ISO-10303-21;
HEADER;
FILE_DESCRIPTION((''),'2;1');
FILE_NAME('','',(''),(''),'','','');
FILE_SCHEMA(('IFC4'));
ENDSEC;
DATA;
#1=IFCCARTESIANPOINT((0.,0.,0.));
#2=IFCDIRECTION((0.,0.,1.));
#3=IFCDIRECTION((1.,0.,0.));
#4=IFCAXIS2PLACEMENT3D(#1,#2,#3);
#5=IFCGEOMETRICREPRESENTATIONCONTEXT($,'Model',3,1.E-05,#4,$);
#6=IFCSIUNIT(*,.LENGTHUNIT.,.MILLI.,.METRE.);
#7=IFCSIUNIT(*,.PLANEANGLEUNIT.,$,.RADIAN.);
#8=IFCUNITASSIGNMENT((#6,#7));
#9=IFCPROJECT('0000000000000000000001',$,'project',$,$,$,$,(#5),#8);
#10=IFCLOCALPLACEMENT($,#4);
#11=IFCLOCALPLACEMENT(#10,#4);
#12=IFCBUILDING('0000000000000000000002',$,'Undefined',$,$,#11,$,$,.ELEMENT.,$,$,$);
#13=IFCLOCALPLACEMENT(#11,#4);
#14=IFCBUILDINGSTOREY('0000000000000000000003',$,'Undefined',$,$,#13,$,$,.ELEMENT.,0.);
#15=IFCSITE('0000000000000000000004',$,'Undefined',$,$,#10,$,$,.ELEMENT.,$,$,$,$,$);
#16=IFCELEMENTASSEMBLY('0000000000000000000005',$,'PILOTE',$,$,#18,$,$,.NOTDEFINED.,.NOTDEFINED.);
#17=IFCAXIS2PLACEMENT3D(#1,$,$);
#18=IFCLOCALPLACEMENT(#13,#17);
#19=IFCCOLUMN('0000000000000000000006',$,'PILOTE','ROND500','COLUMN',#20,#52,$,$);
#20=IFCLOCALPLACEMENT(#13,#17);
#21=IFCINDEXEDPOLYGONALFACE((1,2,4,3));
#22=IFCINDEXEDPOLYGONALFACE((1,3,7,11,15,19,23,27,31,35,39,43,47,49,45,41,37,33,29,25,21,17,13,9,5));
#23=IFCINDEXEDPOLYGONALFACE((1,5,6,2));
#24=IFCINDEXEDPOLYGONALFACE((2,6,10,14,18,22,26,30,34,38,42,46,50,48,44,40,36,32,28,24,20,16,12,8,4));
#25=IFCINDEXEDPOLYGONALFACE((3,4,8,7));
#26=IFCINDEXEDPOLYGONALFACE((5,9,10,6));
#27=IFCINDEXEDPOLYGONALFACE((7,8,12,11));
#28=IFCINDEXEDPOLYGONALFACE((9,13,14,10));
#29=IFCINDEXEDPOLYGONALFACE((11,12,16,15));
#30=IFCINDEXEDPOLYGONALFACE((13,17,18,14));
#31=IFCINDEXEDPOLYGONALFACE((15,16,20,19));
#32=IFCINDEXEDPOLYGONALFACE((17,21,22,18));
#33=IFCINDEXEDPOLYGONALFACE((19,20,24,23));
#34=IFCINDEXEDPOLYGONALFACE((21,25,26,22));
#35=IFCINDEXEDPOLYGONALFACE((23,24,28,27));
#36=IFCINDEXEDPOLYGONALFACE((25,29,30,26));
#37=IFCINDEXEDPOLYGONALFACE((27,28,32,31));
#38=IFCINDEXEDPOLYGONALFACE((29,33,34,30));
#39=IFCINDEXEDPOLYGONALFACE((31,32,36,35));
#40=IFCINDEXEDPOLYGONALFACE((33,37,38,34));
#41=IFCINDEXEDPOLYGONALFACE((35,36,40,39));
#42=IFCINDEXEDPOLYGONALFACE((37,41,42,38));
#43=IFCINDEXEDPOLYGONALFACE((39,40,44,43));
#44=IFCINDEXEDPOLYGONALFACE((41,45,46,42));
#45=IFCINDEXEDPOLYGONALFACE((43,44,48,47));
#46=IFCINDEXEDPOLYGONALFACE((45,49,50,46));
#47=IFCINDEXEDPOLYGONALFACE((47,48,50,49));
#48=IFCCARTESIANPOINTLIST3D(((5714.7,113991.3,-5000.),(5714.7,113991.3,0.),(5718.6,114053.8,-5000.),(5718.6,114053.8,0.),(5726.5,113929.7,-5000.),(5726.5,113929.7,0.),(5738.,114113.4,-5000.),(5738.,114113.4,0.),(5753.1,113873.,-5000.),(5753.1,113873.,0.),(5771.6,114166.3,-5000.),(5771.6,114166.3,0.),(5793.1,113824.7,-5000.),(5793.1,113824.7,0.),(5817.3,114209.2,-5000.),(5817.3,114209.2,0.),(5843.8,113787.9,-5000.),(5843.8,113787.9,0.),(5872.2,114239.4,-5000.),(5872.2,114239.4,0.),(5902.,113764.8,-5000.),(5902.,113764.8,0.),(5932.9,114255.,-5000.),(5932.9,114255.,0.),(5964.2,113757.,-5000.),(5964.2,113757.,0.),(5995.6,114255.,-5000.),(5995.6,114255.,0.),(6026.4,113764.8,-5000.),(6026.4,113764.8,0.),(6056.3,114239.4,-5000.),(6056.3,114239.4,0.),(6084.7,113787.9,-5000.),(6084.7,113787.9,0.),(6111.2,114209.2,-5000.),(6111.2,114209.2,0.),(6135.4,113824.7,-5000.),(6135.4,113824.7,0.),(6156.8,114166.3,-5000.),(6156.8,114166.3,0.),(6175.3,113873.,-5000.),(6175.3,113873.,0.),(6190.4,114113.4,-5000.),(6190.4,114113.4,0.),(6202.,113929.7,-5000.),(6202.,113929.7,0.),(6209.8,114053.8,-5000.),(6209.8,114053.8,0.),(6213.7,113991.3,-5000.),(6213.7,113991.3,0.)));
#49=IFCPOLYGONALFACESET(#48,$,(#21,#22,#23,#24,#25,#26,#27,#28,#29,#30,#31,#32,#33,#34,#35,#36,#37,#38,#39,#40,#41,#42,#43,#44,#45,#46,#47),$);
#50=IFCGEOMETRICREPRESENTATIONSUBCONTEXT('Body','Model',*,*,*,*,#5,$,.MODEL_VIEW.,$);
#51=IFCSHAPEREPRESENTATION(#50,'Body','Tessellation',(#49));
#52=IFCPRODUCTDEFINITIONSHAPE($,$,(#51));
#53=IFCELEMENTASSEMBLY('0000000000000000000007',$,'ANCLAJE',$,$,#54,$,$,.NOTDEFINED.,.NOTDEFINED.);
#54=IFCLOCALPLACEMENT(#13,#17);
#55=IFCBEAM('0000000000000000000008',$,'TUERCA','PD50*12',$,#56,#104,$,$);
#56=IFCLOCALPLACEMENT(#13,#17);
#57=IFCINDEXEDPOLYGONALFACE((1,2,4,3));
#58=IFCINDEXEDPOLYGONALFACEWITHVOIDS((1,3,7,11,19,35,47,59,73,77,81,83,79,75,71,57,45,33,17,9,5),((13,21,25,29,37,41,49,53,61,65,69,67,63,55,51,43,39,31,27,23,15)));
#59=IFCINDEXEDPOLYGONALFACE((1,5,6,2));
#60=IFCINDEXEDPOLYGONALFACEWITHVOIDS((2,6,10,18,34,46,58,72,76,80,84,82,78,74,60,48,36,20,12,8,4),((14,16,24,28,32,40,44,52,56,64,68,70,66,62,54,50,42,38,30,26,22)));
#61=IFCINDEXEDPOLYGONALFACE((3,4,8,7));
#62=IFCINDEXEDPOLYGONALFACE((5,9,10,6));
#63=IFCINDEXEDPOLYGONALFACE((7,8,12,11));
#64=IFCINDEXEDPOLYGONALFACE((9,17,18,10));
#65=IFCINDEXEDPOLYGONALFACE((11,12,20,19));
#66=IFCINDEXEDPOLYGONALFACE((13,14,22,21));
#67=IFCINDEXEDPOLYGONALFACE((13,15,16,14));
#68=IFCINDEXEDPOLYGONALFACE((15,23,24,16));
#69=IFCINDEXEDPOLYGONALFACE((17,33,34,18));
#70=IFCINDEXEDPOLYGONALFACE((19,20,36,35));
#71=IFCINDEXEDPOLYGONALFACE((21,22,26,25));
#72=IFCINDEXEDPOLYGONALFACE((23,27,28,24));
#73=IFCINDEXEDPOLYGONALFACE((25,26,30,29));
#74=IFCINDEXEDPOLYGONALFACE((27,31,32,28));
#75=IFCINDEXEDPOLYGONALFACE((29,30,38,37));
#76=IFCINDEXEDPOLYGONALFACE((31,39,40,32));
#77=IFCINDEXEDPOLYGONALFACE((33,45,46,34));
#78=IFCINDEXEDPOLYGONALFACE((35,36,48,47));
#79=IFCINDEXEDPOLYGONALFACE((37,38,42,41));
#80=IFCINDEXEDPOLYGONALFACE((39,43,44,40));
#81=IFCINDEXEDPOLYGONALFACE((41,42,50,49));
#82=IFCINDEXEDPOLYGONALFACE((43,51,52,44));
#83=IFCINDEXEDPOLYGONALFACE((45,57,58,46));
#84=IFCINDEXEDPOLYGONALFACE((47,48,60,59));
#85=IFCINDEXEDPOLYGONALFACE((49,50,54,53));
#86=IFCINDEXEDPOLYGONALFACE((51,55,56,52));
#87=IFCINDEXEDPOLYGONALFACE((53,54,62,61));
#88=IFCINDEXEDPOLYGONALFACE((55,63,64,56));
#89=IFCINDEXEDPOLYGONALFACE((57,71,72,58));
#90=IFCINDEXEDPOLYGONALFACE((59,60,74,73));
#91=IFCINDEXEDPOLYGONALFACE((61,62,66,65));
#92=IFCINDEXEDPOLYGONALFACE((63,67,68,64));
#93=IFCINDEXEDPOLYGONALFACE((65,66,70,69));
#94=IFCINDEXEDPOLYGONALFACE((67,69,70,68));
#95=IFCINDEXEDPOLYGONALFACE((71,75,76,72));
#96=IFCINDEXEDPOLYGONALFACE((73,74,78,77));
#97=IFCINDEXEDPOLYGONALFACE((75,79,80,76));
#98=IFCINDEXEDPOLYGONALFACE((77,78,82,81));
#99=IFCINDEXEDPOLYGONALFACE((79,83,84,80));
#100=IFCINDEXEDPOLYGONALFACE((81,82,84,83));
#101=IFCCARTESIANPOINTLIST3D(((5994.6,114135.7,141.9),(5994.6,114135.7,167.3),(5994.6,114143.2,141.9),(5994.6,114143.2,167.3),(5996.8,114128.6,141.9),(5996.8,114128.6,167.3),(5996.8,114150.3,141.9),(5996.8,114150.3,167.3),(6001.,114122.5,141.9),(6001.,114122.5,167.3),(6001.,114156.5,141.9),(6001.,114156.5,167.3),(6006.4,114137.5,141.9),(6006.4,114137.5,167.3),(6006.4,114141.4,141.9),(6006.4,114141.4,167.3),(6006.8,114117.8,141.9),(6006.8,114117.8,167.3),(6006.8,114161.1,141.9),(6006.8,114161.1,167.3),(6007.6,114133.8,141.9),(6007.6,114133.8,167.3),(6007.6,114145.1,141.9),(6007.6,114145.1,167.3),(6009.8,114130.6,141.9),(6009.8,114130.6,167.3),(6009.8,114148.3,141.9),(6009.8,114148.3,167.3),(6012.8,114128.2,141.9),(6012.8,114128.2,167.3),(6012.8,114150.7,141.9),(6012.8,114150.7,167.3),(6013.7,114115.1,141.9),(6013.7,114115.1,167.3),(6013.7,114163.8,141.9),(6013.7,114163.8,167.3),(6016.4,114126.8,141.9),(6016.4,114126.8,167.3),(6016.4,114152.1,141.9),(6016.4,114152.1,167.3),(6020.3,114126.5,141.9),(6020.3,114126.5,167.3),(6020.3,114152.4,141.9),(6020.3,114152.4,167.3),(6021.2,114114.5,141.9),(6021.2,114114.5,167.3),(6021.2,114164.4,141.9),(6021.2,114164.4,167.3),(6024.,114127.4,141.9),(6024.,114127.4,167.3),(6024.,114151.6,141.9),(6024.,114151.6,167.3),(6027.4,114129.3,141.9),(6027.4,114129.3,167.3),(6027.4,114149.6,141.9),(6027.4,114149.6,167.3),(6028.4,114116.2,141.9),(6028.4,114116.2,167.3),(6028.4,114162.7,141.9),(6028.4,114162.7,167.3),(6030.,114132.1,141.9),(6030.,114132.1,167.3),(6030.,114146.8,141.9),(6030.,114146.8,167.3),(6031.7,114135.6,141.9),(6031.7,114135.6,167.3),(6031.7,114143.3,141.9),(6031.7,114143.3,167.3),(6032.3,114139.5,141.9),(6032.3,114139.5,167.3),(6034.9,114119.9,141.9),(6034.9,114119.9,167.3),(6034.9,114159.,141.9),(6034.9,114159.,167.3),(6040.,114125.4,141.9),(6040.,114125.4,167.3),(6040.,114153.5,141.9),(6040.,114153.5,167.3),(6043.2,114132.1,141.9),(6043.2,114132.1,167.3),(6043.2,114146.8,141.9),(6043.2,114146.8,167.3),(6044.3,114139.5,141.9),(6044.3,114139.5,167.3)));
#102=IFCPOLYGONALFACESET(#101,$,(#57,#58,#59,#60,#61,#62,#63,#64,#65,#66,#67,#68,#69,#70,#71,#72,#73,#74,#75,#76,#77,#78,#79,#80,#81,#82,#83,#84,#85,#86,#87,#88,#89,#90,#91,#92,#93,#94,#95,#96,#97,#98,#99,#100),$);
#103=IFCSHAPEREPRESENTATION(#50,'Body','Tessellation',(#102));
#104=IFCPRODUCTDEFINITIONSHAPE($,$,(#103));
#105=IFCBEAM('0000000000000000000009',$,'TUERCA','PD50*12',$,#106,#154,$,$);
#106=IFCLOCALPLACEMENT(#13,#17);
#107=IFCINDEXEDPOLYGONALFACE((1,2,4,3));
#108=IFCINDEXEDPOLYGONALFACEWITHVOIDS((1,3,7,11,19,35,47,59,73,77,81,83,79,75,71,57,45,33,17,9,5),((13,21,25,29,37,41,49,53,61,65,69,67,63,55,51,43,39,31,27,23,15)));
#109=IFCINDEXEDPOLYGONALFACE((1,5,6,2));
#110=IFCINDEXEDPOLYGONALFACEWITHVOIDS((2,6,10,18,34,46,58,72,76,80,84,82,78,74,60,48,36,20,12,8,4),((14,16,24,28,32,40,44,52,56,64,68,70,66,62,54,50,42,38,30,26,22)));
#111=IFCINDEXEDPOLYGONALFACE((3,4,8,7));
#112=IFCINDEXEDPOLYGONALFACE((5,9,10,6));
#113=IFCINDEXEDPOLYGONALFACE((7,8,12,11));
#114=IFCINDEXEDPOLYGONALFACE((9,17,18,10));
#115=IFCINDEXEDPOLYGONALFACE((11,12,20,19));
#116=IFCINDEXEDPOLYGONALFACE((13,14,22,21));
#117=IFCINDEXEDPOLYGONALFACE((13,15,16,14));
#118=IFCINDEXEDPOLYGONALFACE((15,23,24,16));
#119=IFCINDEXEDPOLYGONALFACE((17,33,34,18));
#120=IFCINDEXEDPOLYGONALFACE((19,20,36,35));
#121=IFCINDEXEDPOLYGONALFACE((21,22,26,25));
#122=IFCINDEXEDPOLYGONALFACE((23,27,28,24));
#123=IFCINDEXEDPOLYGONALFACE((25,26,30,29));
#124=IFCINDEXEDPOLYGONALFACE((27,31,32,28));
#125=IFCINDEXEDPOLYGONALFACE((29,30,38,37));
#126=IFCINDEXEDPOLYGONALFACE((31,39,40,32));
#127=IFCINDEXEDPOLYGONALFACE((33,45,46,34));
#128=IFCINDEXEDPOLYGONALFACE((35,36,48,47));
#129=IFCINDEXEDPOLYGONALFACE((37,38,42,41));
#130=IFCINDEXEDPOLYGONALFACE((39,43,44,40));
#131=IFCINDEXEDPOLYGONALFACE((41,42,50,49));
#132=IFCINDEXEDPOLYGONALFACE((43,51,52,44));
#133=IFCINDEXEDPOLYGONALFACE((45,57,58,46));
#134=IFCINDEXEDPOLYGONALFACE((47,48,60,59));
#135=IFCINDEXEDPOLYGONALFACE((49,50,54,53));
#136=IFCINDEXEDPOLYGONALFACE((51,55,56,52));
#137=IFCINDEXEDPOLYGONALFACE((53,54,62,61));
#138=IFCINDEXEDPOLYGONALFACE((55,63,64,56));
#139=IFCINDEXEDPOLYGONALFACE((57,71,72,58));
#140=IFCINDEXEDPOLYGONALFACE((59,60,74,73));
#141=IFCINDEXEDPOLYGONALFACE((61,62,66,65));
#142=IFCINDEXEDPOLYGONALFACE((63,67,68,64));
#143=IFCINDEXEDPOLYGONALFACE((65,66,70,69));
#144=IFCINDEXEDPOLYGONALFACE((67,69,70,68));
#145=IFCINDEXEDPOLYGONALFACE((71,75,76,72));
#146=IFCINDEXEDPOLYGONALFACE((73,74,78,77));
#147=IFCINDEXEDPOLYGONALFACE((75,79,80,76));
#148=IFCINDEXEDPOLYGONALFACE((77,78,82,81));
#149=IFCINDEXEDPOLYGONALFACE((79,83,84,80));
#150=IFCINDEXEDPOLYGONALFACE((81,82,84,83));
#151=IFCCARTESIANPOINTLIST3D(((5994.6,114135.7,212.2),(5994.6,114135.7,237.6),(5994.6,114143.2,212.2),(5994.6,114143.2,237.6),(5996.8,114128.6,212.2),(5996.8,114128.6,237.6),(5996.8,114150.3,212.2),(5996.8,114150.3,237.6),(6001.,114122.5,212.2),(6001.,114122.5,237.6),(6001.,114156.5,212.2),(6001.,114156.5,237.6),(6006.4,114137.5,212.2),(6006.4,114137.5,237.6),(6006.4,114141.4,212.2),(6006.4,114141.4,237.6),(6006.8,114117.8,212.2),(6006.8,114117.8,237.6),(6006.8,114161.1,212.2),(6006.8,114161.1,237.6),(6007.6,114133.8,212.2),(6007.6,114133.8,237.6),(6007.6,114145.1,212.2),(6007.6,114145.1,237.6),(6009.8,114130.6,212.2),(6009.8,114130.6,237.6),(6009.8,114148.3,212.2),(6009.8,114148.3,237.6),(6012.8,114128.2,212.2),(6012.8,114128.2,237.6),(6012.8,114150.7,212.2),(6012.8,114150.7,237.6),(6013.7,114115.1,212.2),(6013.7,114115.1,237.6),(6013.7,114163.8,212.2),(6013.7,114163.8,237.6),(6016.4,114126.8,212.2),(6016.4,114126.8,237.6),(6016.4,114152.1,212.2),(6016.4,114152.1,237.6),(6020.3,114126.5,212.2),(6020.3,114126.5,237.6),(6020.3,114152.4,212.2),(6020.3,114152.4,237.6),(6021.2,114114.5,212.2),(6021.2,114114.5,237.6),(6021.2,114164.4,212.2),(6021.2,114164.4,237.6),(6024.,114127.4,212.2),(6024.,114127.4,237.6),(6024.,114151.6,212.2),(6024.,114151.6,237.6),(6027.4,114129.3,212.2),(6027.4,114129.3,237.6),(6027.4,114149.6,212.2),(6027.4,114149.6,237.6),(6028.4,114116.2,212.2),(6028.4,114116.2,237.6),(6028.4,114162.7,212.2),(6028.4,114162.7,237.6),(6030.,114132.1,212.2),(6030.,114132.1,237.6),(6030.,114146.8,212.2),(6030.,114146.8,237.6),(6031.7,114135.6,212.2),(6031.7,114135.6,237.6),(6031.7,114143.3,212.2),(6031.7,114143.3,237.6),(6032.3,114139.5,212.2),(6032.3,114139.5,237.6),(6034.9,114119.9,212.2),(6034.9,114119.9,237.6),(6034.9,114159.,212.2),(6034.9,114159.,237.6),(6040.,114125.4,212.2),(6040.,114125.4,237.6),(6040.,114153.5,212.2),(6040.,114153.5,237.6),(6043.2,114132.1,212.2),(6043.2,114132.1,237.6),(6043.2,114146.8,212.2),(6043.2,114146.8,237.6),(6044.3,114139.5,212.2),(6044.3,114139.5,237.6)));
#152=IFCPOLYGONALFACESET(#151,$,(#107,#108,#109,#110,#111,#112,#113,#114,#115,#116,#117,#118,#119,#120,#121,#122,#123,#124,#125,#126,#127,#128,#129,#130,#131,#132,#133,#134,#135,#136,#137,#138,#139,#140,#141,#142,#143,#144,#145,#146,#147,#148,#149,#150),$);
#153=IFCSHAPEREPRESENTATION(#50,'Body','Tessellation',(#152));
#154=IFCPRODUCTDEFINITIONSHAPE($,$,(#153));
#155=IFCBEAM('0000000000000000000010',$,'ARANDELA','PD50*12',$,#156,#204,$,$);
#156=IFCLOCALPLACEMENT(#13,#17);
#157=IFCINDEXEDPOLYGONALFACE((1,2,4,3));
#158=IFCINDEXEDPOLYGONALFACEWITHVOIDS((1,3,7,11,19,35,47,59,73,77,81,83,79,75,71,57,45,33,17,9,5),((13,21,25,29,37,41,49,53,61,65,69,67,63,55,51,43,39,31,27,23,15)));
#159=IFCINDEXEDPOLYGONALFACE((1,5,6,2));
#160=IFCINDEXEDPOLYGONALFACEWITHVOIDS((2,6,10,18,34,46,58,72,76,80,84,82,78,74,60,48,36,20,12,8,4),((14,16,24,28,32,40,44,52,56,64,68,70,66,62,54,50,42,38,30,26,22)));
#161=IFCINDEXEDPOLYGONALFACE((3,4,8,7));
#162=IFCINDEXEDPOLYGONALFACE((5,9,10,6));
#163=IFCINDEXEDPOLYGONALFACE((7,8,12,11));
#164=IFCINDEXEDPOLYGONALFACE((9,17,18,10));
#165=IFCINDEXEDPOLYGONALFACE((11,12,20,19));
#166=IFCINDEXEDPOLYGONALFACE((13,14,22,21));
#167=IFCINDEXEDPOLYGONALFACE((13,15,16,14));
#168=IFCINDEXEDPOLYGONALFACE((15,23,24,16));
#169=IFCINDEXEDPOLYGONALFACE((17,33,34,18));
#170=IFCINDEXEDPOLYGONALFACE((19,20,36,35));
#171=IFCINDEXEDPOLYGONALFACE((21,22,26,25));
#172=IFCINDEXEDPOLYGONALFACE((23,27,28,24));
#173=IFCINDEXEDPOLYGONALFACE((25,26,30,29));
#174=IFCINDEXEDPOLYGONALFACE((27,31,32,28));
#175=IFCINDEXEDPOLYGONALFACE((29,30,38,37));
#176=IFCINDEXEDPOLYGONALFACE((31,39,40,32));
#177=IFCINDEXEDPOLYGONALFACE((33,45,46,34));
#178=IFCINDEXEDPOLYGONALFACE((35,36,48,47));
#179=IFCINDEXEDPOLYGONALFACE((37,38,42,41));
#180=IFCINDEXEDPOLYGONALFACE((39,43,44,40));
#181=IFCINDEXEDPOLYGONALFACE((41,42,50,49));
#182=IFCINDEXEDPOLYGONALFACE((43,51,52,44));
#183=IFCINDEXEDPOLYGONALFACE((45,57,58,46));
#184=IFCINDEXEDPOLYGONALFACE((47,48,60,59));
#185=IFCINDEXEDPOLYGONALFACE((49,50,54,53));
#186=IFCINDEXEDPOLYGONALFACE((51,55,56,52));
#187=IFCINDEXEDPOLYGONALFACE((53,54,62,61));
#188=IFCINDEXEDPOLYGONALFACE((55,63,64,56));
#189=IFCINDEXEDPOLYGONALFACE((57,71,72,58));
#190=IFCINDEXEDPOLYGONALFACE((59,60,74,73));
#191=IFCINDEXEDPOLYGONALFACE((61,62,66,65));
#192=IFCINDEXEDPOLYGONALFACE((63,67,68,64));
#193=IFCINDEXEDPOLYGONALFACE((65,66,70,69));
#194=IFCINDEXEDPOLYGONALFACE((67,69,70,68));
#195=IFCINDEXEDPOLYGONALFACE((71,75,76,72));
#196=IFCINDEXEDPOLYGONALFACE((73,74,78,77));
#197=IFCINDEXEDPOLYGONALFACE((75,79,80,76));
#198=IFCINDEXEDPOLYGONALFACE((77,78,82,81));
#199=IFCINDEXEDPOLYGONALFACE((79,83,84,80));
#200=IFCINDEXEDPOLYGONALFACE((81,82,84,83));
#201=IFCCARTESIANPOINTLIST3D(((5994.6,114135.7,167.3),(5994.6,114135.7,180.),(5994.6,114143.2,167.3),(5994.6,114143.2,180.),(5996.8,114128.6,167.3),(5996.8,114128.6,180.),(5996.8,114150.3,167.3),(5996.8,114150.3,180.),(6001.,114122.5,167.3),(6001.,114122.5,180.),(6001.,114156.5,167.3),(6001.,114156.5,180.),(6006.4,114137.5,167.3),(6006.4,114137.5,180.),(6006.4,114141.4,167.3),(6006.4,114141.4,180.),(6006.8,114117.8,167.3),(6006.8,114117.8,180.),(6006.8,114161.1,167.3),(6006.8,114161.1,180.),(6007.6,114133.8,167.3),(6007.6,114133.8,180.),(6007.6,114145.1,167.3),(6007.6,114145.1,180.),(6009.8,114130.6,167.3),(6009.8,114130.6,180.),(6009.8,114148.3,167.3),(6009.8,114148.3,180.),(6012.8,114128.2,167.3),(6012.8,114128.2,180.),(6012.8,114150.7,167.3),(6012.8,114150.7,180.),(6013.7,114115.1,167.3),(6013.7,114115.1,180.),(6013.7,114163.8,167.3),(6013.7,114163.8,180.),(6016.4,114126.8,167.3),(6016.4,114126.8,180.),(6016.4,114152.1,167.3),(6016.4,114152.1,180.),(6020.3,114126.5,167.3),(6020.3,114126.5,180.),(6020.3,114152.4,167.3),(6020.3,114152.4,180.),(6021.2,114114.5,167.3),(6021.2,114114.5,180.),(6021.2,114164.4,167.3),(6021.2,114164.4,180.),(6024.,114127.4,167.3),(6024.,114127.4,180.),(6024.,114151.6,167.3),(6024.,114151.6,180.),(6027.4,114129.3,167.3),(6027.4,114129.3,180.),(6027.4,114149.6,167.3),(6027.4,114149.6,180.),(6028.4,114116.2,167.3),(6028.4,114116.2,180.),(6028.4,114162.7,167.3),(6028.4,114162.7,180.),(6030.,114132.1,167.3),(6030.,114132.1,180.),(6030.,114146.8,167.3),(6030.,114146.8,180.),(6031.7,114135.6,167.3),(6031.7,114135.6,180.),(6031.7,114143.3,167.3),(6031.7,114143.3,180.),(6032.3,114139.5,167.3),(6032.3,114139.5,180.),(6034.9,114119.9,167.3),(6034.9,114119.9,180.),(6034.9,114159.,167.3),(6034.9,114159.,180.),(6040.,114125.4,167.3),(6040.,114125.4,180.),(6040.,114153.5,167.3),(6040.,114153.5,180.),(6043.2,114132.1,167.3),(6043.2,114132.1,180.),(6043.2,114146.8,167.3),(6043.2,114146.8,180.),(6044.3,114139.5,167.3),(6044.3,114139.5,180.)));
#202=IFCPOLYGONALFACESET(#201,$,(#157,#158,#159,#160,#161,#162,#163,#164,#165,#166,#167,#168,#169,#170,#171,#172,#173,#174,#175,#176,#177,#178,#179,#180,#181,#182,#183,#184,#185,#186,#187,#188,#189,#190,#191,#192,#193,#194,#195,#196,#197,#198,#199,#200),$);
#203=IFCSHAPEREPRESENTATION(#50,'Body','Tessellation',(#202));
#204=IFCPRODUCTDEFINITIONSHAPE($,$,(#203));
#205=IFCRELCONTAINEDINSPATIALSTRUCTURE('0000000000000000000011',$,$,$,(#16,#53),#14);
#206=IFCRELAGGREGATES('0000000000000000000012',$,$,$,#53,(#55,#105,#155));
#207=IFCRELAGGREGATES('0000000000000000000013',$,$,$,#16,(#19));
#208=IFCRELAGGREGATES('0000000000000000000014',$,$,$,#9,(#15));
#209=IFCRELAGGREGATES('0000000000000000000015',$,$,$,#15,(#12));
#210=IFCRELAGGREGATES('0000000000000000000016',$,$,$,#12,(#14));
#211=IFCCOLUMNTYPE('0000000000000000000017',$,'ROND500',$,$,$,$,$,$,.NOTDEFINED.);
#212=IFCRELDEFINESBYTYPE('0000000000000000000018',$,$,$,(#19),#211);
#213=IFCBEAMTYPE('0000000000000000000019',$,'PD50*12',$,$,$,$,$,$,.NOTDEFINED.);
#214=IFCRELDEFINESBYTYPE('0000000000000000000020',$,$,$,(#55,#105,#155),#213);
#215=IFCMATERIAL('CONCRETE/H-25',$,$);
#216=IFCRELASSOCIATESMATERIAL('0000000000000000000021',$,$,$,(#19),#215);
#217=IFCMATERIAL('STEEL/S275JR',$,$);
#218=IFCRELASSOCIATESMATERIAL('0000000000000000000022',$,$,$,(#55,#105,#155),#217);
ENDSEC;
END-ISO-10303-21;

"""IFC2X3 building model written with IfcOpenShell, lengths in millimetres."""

from ifc_helpers import new_model, si_unit, frame, origin_with_axes, origin_2d_with_axis, place, context, subcontext, project, spatial, circle, hollow_circle, extrude, material, type_object, element, aggregate, save


model = new_model("IFC2X3")

# Units and contexts
model_context = context("Model", 3, precision=1e-05, world=origin_with_axes())
body_context = subcontext(model_context, "Body", "Model", "MODEL_VIEW")
ifc_project = project(units=[si_unit("LENGTHUNIT", "METRE", prefix="MILLI"), si_unit("PLANEANGLEUNIT", "RADIAN")], contexts=[model_context])

# Site, building, storey
site_placement = place(None, origin_with_axes())
site = spatial("IfcSite", under=ifc_project, at=site_placement, Name="Undefined", CompositionType="ELEMENT")
building_placement = place(site_placement, origin_with_axes())
building = spatial("IfcBuilding", under=site, at=building_placement, Name="Undefined", CompositionType="ELEMENT")
storey_placement = place(building_placement, origin_with_axes())
storey = spatial("IfcBuildingStorey", under=building, at=storey_placement, Name="Undefined", CompositionType="ELEMENT", Elevation=0.0)

# Element assembly, column
assembly_1_placement = place(storey_placement, origin_with_axes())
assembly_1 = element("IfcElementAssembly", 1, at=assembly_1_placement, inside=storey, Name="PILOTE", AssemblyPlace="NOTDEFINED", PredefinedType="NOTDEFINED")
ifc_material_1 = material(Name="CONCRETE/H-25")
column_type = type_object("IfcColumnType", Name="ROND500", PredefinedType="NOTDEFINED")
column_placement = place(assembly_1_placement, frame((5964.2, 114007.0, 0.0), z_axis=(0.0, 0.0, -1.0), x_axis=(1.0, 0.0, 0.0)))
column = element("IfcColumn", 2, at=column_placement, type_object=column_type, material=ifc_material_1, Name="PILOTE", Description="ROND500", ObjectType="COLUMN", context=body_context, shape_type="SweptSolid", body=[
    extrude(circle(Radius=250.0, at=origin_2d_with_axis()), frame((0.0, 0.0, 5000.0), z_axis=(0.0, 0.0, -1.0), x_axis=(0.0, 1.0, 0.0)), (0.0, 0.0, 1.0), 5000.0),
])

# Element assembly, beams
assembly_2_placement = place(storey_placement, origin_with_axes())
assembly_2 = element("IfcElementAssembly", 3, at=assembly_2_placement, inside=storey, Name="ANCLAJE", AssemblyPlace="NOTDEFINED", PredefinedType="NOTDEFINED")
ifc_material_2 = material(Name="STEEL/S275JR")
beam_type_1 = type_object("IfcBeamType", Name="PD50*12", PredefinedType="NOTDEFINED")
beam_1_placement = place(assembly_2_placement, frame((6019.3, 114139.5, 167.3), z_axis=(0.0, 1.0, 0.0), x_axis=(0.0, 0.0, -1.0)))
beam_1 = element("IfcBeam", 4, at=beam_1_placement, type_object=beam_type_1, material=ifc_material_2, Name="TUERCA", Description="PD50*12", context=body_context, shape_type="SweptSolid", body=[
    extrude(hollow_circle(Radius=25.0, WallThickness=12.0, at=origin_2d_with_axis()), frame((25.4, 0.0, 0.0), z_axis=(-1.0, 0.0, 0.0), x_axis=(0.0, -1.0, 0.0)), (0.0, 0.0, 1.0), 25.4),
])
beam_2_placement = place(assembly_2_placement, frame((6019.3, 114139.5, 237.6), z_axis=(0.0, 1.0, 0.0), x_axis=(0.0, 0.0, -1.0)))
beam_2 = element("IfcBeam", 5, at=beam_2_placement, type_object=beam_type_1, material=ifc_material_2, Name="TUERCA", Description="PD50*12", context=body_context, shape_type="SweptSolid", body=[
    extrude(hollow_circle(Radius=25.0, WallThickness=12.0, at=origin_2d_with_axis()), frame((25.4, 0.0, 0.0), z_axis=(-1.0, 0.0, 0.0), x_axis=(0.0, -1.0, 0.0)), (0.0, 0.0, 1.0), 25.4),
])
beam_3_placement = place(assembly_2_placement, frame((6019.3, 114139.5, 180.0), z_axis=(0.0, 1.0, 0.0), x_axis=(0.0, 0.0, -1.0)))
beam_3 = element("IfcBeam", 6, at=beam_3_placement, type_object=beam_type_1, material=ifc_material_2, Name="ARANDELA", Description="PD50*12", context=body_context, shape_type="SweptSolid", body=[
    extrude(hollow_circle(Radius=25.0, WallThickness=12.0, at=origin_2d_with_axis()), frame((12.7, 0.0, 0.0), z_axis=(-1.0, 0.0, 0.0), x_axis=(0.0, -1.0, 0.0)), (0.0, 0.0, 1.0), 12.7),
])

aggregate(assembly_2, [beam_1, beam_2, beam_3])

aggregate(assembly_1, [column])

save(model, "model.ifc")
